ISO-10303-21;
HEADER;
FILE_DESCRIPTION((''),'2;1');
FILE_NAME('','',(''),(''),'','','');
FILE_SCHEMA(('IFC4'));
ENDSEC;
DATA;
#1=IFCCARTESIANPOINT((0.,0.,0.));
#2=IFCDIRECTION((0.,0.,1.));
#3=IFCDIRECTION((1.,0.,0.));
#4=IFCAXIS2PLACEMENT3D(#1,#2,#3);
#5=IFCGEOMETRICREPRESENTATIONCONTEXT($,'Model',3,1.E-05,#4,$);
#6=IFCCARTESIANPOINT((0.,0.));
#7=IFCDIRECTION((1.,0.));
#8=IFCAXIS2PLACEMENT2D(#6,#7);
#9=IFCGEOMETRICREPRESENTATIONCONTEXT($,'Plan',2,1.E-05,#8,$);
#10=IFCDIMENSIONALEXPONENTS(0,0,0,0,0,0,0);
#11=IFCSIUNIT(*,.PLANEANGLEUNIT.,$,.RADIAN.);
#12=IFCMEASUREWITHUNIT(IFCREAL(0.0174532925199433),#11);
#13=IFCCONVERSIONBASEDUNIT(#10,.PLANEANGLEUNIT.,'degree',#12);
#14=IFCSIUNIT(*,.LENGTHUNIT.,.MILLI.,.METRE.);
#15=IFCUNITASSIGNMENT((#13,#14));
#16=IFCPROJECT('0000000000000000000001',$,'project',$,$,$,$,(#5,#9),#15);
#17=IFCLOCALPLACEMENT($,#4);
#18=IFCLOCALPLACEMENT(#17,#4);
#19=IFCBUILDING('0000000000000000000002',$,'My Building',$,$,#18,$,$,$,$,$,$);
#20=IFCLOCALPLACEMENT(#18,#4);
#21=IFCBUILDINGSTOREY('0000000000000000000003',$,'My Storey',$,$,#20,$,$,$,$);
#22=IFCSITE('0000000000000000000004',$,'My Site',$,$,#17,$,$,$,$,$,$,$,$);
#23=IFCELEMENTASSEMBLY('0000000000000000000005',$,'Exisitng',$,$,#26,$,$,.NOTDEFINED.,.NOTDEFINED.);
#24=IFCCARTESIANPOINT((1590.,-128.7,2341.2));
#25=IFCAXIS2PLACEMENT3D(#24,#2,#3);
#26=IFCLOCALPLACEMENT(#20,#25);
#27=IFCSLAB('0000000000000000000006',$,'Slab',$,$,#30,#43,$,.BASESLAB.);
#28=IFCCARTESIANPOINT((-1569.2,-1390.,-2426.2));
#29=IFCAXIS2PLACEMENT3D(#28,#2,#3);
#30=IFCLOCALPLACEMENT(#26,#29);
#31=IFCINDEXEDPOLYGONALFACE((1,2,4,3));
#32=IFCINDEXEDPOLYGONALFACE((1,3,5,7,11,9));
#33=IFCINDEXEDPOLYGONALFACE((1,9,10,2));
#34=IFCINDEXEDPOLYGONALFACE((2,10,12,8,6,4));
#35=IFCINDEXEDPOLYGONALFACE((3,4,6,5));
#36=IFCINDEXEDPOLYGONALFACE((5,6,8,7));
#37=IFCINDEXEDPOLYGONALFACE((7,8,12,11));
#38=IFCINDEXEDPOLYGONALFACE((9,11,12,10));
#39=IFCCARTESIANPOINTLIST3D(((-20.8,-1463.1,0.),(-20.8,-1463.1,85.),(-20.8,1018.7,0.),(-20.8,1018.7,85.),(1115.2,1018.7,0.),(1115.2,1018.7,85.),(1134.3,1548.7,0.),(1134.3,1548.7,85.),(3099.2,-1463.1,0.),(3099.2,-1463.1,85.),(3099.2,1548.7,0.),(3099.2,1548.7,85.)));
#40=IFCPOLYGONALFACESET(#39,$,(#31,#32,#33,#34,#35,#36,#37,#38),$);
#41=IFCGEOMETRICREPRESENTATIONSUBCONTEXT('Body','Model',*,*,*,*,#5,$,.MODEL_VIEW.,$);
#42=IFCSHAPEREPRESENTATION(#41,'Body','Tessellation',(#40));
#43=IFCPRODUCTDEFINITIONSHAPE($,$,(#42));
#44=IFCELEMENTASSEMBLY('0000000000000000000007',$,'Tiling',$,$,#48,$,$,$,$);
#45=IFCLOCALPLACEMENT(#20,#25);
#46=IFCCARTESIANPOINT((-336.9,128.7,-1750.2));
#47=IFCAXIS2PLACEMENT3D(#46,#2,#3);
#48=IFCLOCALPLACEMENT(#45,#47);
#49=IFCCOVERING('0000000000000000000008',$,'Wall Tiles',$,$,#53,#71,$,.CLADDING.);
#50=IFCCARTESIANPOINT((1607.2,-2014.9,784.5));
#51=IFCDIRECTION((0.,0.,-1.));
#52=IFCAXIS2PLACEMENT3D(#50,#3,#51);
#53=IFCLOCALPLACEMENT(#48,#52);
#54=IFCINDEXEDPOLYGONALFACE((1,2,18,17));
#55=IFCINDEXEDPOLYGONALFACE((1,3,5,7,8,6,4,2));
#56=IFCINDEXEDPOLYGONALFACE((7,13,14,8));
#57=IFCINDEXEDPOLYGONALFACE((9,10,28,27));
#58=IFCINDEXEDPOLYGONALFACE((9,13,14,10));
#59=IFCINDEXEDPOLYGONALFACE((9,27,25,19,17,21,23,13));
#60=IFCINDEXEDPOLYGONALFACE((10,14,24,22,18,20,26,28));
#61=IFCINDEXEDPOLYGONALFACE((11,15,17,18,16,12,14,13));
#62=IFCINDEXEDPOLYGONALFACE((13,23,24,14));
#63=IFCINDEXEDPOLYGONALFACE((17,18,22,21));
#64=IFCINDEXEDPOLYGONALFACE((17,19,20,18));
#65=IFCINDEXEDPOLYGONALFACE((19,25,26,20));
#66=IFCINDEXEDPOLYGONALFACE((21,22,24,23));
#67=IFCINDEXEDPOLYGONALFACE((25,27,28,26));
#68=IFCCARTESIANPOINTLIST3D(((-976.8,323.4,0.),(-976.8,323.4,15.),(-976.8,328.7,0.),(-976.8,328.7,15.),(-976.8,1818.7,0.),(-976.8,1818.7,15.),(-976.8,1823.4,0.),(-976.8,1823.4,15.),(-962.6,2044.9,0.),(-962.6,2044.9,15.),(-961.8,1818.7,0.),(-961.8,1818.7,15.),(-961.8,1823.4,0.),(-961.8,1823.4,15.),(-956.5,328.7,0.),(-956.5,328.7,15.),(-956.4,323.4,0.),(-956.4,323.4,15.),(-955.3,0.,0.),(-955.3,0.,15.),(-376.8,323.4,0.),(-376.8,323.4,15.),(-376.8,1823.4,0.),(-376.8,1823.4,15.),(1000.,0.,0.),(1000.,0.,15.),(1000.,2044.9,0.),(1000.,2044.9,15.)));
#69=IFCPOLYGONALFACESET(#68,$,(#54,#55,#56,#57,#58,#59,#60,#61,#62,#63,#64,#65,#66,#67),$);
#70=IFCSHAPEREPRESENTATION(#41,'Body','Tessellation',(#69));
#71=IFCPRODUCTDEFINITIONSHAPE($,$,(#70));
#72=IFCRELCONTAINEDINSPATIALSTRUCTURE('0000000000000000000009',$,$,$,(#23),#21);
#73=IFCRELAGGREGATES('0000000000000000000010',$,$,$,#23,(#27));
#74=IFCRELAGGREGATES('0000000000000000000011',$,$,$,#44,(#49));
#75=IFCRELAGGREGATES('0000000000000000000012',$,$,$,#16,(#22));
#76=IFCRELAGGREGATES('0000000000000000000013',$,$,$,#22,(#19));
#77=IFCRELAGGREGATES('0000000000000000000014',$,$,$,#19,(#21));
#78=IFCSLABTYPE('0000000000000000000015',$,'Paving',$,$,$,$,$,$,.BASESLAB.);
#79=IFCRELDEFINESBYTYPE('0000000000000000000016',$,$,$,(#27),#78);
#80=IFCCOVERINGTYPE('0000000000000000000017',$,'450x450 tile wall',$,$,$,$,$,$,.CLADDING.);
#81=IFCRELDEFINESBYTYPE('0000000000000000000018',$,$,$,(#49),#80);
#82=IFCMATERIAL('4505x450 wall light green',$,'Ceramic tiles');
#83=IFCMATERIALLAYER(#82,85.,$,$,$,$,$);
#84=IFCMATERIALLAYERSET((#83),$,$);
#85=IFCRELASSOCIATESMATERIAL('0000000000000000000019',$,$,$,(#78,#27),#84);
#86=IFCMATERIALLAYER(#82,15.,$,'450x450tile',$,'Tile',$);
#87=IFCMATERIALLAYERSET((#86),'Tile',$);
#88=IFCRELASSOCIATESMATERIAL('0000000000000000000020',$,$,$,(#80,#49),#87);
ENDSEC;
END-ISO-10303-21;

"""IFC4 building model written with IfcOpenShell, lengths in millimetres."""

from ifc_helpers import new_model, entity, si_unit, converted_unit, frame, origin_with_axes, origin_2d_with_axis, place, context, subcontext, project, spatial, line, indexed_curve, outline, extrude, material, layer, layer_set, layer_usage, type_object, element, aggregate, save


model = new_model("IFC4")

# Units and contexts
model_context = context("Model", 3, precision=1e-05, world=origin_with_axes())
plan_context = context("Plan", 2, precision=1e-05, world=origin_2d_with_axis())
body_context = subcontext(model_context, "Body", "Model", "MODEL_VIEW")
ifc_project = project(units=[converted_unit("PLANEANGLEUNIT", "degree", entity("IfcReal", 0.0174532925199433), si_unit("PLANEANGLEUNIT", "RADIAN"), dimensions=[0, 0, 0, 0, 0, 0, 0]), si_unit("LENGTHUNIT", "METRE", prefix="MILLI")], contexts=[model_context, plan_context])

# Site, building, storey
site_placement = place(None, origin_with_axes())
site = spatial("IfcSite", under=ifc_project, at=site_placement, Name="My Site")
building_placement = place(site_placement, origin_with_axes())
building = spatial("IfcBuilding", under=site, at=building_placement, Name="My Building")
storey_placement = place(building_placement, origin_with_axes())
storey = spatial("IfcBuildingStorey", under=building, at=storey_placement, Name="My Storey")

# Shared definitions
assembly_1_placement = place(storey_placement, frame((1590.0, -128.7, 2341.2), z_axis=(0.0, 0.0, 1.0), x_axis=(1.0, 0.0, 0.0)))

# Element assemblies, slab
assembly_2_placement = place(storey_placement, frame((1590.0, -128.7, 2341.2), z_axis=(0.0, 0.0, 1.0), x_axis=(1.0, 0.0, 0.0)))
assembly_2 = element("IfcElementAssembly", 1, at=assembly_2_placement, inside=storey, Name="Exisitng", AssemblyPlace="NOTDEFINED", PredefinedType="NOTDEFINED")
ifc_material_1 = material(Name="4505x450 wall light green", Category="Ceramic tiles")
ifc_layer_1 = layer(ifc_material_1, 85.0)
ifc_layer_set_1 = layer_set([ifc_layer_1])
ifc_layer_usage_1 = layer_usage(ifc_layer_set_1, "AXIS3", "POSITIVE", 0.0)
slab_type_1 = type_object("IfcSlabType", Name="Paving", PredefinedType="BASESLAB", material=ifc_layer_set_1)
slab_1_placement = place(assembly_2_placement, frame((-1569.2, -1390.0, -2426.2), z_axis=(0.0, 0.0, 1.0), x_axis=(1.0, 0.0, 0.0)))
slab_1 = element("IfcSlab", 2, at=slab_1_placement, type_object=slab_type_1, material=ifc_layer_usage_1, Name="Slab", PredefinedType="BASESLAB", context=body_context, shape_type="SweptSolid", body=[
    extrude(outline(indexed_curve([(-20.8, -1463.1), (3099.2, -1463.1), (-20.8, 1018.7), (1134.3, 1548.7), (1115.2, 1018.7), (3099.2, 1548.7)], segments=[line(2, 1), line(1, 3), line(3, 5), line(5, 4), line(4, 6), line(6, 2)], self_intersect=False)), None, (0.0, 0.0, 1.0), 85.0),
])
aggregate(assembly_2, [slab_1])
assembly_3_placement = place(assembly_1_placement, frame((-336.9, 128.7, -1750.2), z_axis=(0.0, 0.0, 1.0), x_axis=(1.0, 0.0, 0.0)))
assembly_3 = element("IfcElementAssembly", 3, at=assembly_3_placement, Name="Tiling")

# Covering
ifc_layer_2 = layer(ifc_material_1, 15.0, Name="450x450tile", Category="Tile")
ifc_layer_set_2 = layer_set([ifc_layer_2], Name="Tile")
covering_type_1 = type_object("IfcCoveringType", Name="450x450 tile wall", PredefinedType="CLADDING", material=ifc_layer_set_2)
ifc_layer_usage_2 = layer_usage(ifc_layer_set_2, "AXIS3", "POSITIVE", 0.0)
covering_1_placement = place(assembly_3_placement, frame((1607.2, -2014.9, 784.5), z_axis=(1.0, 0.0, 0.0), x_axis=(0.0, 0.0, -1.0)))
covering_1 = element("IfcCovering", 4, at=covering_1_placement, type_object=covering_type_1, material=ifc_layer_usage_2, Name="Wall Tiles", PredefinedType="CLADDING", context=body_context, shape_type="SweptSolid", body=[
    extrude(outline(indexed_curve([(1000.0, 0.0), (1000.0, 2044.9), (-962.6, 2044.9), (-955.3, 0.0), (-976.8, 1823.4), (-376.8, 1823.4), (-376.8, 323.4), (-976.8, 323.4)], segments=[line(4, 3), line(3, 2), line(2, 1), line(1, 4)], self_intersect=False), holes=[indexed_curve([(1000.0, 0.0), (1000.0, 2044.9), (-962.6, 2044.9), (-955.3, 0.0), (-976.8, 1823.4), (-376.8, 1823.4), (-376.8, 323.4), (-976.8, 323.4)], segments=[line(6, 7), line(7, 8), line(8, 5), line(5, 6)], self_intersect=False)]), None, (0.0, 0.0, 1.0), 15.0),
])
aggregate(assembly_3, [covering_1])

save(model, "model.ifc")
